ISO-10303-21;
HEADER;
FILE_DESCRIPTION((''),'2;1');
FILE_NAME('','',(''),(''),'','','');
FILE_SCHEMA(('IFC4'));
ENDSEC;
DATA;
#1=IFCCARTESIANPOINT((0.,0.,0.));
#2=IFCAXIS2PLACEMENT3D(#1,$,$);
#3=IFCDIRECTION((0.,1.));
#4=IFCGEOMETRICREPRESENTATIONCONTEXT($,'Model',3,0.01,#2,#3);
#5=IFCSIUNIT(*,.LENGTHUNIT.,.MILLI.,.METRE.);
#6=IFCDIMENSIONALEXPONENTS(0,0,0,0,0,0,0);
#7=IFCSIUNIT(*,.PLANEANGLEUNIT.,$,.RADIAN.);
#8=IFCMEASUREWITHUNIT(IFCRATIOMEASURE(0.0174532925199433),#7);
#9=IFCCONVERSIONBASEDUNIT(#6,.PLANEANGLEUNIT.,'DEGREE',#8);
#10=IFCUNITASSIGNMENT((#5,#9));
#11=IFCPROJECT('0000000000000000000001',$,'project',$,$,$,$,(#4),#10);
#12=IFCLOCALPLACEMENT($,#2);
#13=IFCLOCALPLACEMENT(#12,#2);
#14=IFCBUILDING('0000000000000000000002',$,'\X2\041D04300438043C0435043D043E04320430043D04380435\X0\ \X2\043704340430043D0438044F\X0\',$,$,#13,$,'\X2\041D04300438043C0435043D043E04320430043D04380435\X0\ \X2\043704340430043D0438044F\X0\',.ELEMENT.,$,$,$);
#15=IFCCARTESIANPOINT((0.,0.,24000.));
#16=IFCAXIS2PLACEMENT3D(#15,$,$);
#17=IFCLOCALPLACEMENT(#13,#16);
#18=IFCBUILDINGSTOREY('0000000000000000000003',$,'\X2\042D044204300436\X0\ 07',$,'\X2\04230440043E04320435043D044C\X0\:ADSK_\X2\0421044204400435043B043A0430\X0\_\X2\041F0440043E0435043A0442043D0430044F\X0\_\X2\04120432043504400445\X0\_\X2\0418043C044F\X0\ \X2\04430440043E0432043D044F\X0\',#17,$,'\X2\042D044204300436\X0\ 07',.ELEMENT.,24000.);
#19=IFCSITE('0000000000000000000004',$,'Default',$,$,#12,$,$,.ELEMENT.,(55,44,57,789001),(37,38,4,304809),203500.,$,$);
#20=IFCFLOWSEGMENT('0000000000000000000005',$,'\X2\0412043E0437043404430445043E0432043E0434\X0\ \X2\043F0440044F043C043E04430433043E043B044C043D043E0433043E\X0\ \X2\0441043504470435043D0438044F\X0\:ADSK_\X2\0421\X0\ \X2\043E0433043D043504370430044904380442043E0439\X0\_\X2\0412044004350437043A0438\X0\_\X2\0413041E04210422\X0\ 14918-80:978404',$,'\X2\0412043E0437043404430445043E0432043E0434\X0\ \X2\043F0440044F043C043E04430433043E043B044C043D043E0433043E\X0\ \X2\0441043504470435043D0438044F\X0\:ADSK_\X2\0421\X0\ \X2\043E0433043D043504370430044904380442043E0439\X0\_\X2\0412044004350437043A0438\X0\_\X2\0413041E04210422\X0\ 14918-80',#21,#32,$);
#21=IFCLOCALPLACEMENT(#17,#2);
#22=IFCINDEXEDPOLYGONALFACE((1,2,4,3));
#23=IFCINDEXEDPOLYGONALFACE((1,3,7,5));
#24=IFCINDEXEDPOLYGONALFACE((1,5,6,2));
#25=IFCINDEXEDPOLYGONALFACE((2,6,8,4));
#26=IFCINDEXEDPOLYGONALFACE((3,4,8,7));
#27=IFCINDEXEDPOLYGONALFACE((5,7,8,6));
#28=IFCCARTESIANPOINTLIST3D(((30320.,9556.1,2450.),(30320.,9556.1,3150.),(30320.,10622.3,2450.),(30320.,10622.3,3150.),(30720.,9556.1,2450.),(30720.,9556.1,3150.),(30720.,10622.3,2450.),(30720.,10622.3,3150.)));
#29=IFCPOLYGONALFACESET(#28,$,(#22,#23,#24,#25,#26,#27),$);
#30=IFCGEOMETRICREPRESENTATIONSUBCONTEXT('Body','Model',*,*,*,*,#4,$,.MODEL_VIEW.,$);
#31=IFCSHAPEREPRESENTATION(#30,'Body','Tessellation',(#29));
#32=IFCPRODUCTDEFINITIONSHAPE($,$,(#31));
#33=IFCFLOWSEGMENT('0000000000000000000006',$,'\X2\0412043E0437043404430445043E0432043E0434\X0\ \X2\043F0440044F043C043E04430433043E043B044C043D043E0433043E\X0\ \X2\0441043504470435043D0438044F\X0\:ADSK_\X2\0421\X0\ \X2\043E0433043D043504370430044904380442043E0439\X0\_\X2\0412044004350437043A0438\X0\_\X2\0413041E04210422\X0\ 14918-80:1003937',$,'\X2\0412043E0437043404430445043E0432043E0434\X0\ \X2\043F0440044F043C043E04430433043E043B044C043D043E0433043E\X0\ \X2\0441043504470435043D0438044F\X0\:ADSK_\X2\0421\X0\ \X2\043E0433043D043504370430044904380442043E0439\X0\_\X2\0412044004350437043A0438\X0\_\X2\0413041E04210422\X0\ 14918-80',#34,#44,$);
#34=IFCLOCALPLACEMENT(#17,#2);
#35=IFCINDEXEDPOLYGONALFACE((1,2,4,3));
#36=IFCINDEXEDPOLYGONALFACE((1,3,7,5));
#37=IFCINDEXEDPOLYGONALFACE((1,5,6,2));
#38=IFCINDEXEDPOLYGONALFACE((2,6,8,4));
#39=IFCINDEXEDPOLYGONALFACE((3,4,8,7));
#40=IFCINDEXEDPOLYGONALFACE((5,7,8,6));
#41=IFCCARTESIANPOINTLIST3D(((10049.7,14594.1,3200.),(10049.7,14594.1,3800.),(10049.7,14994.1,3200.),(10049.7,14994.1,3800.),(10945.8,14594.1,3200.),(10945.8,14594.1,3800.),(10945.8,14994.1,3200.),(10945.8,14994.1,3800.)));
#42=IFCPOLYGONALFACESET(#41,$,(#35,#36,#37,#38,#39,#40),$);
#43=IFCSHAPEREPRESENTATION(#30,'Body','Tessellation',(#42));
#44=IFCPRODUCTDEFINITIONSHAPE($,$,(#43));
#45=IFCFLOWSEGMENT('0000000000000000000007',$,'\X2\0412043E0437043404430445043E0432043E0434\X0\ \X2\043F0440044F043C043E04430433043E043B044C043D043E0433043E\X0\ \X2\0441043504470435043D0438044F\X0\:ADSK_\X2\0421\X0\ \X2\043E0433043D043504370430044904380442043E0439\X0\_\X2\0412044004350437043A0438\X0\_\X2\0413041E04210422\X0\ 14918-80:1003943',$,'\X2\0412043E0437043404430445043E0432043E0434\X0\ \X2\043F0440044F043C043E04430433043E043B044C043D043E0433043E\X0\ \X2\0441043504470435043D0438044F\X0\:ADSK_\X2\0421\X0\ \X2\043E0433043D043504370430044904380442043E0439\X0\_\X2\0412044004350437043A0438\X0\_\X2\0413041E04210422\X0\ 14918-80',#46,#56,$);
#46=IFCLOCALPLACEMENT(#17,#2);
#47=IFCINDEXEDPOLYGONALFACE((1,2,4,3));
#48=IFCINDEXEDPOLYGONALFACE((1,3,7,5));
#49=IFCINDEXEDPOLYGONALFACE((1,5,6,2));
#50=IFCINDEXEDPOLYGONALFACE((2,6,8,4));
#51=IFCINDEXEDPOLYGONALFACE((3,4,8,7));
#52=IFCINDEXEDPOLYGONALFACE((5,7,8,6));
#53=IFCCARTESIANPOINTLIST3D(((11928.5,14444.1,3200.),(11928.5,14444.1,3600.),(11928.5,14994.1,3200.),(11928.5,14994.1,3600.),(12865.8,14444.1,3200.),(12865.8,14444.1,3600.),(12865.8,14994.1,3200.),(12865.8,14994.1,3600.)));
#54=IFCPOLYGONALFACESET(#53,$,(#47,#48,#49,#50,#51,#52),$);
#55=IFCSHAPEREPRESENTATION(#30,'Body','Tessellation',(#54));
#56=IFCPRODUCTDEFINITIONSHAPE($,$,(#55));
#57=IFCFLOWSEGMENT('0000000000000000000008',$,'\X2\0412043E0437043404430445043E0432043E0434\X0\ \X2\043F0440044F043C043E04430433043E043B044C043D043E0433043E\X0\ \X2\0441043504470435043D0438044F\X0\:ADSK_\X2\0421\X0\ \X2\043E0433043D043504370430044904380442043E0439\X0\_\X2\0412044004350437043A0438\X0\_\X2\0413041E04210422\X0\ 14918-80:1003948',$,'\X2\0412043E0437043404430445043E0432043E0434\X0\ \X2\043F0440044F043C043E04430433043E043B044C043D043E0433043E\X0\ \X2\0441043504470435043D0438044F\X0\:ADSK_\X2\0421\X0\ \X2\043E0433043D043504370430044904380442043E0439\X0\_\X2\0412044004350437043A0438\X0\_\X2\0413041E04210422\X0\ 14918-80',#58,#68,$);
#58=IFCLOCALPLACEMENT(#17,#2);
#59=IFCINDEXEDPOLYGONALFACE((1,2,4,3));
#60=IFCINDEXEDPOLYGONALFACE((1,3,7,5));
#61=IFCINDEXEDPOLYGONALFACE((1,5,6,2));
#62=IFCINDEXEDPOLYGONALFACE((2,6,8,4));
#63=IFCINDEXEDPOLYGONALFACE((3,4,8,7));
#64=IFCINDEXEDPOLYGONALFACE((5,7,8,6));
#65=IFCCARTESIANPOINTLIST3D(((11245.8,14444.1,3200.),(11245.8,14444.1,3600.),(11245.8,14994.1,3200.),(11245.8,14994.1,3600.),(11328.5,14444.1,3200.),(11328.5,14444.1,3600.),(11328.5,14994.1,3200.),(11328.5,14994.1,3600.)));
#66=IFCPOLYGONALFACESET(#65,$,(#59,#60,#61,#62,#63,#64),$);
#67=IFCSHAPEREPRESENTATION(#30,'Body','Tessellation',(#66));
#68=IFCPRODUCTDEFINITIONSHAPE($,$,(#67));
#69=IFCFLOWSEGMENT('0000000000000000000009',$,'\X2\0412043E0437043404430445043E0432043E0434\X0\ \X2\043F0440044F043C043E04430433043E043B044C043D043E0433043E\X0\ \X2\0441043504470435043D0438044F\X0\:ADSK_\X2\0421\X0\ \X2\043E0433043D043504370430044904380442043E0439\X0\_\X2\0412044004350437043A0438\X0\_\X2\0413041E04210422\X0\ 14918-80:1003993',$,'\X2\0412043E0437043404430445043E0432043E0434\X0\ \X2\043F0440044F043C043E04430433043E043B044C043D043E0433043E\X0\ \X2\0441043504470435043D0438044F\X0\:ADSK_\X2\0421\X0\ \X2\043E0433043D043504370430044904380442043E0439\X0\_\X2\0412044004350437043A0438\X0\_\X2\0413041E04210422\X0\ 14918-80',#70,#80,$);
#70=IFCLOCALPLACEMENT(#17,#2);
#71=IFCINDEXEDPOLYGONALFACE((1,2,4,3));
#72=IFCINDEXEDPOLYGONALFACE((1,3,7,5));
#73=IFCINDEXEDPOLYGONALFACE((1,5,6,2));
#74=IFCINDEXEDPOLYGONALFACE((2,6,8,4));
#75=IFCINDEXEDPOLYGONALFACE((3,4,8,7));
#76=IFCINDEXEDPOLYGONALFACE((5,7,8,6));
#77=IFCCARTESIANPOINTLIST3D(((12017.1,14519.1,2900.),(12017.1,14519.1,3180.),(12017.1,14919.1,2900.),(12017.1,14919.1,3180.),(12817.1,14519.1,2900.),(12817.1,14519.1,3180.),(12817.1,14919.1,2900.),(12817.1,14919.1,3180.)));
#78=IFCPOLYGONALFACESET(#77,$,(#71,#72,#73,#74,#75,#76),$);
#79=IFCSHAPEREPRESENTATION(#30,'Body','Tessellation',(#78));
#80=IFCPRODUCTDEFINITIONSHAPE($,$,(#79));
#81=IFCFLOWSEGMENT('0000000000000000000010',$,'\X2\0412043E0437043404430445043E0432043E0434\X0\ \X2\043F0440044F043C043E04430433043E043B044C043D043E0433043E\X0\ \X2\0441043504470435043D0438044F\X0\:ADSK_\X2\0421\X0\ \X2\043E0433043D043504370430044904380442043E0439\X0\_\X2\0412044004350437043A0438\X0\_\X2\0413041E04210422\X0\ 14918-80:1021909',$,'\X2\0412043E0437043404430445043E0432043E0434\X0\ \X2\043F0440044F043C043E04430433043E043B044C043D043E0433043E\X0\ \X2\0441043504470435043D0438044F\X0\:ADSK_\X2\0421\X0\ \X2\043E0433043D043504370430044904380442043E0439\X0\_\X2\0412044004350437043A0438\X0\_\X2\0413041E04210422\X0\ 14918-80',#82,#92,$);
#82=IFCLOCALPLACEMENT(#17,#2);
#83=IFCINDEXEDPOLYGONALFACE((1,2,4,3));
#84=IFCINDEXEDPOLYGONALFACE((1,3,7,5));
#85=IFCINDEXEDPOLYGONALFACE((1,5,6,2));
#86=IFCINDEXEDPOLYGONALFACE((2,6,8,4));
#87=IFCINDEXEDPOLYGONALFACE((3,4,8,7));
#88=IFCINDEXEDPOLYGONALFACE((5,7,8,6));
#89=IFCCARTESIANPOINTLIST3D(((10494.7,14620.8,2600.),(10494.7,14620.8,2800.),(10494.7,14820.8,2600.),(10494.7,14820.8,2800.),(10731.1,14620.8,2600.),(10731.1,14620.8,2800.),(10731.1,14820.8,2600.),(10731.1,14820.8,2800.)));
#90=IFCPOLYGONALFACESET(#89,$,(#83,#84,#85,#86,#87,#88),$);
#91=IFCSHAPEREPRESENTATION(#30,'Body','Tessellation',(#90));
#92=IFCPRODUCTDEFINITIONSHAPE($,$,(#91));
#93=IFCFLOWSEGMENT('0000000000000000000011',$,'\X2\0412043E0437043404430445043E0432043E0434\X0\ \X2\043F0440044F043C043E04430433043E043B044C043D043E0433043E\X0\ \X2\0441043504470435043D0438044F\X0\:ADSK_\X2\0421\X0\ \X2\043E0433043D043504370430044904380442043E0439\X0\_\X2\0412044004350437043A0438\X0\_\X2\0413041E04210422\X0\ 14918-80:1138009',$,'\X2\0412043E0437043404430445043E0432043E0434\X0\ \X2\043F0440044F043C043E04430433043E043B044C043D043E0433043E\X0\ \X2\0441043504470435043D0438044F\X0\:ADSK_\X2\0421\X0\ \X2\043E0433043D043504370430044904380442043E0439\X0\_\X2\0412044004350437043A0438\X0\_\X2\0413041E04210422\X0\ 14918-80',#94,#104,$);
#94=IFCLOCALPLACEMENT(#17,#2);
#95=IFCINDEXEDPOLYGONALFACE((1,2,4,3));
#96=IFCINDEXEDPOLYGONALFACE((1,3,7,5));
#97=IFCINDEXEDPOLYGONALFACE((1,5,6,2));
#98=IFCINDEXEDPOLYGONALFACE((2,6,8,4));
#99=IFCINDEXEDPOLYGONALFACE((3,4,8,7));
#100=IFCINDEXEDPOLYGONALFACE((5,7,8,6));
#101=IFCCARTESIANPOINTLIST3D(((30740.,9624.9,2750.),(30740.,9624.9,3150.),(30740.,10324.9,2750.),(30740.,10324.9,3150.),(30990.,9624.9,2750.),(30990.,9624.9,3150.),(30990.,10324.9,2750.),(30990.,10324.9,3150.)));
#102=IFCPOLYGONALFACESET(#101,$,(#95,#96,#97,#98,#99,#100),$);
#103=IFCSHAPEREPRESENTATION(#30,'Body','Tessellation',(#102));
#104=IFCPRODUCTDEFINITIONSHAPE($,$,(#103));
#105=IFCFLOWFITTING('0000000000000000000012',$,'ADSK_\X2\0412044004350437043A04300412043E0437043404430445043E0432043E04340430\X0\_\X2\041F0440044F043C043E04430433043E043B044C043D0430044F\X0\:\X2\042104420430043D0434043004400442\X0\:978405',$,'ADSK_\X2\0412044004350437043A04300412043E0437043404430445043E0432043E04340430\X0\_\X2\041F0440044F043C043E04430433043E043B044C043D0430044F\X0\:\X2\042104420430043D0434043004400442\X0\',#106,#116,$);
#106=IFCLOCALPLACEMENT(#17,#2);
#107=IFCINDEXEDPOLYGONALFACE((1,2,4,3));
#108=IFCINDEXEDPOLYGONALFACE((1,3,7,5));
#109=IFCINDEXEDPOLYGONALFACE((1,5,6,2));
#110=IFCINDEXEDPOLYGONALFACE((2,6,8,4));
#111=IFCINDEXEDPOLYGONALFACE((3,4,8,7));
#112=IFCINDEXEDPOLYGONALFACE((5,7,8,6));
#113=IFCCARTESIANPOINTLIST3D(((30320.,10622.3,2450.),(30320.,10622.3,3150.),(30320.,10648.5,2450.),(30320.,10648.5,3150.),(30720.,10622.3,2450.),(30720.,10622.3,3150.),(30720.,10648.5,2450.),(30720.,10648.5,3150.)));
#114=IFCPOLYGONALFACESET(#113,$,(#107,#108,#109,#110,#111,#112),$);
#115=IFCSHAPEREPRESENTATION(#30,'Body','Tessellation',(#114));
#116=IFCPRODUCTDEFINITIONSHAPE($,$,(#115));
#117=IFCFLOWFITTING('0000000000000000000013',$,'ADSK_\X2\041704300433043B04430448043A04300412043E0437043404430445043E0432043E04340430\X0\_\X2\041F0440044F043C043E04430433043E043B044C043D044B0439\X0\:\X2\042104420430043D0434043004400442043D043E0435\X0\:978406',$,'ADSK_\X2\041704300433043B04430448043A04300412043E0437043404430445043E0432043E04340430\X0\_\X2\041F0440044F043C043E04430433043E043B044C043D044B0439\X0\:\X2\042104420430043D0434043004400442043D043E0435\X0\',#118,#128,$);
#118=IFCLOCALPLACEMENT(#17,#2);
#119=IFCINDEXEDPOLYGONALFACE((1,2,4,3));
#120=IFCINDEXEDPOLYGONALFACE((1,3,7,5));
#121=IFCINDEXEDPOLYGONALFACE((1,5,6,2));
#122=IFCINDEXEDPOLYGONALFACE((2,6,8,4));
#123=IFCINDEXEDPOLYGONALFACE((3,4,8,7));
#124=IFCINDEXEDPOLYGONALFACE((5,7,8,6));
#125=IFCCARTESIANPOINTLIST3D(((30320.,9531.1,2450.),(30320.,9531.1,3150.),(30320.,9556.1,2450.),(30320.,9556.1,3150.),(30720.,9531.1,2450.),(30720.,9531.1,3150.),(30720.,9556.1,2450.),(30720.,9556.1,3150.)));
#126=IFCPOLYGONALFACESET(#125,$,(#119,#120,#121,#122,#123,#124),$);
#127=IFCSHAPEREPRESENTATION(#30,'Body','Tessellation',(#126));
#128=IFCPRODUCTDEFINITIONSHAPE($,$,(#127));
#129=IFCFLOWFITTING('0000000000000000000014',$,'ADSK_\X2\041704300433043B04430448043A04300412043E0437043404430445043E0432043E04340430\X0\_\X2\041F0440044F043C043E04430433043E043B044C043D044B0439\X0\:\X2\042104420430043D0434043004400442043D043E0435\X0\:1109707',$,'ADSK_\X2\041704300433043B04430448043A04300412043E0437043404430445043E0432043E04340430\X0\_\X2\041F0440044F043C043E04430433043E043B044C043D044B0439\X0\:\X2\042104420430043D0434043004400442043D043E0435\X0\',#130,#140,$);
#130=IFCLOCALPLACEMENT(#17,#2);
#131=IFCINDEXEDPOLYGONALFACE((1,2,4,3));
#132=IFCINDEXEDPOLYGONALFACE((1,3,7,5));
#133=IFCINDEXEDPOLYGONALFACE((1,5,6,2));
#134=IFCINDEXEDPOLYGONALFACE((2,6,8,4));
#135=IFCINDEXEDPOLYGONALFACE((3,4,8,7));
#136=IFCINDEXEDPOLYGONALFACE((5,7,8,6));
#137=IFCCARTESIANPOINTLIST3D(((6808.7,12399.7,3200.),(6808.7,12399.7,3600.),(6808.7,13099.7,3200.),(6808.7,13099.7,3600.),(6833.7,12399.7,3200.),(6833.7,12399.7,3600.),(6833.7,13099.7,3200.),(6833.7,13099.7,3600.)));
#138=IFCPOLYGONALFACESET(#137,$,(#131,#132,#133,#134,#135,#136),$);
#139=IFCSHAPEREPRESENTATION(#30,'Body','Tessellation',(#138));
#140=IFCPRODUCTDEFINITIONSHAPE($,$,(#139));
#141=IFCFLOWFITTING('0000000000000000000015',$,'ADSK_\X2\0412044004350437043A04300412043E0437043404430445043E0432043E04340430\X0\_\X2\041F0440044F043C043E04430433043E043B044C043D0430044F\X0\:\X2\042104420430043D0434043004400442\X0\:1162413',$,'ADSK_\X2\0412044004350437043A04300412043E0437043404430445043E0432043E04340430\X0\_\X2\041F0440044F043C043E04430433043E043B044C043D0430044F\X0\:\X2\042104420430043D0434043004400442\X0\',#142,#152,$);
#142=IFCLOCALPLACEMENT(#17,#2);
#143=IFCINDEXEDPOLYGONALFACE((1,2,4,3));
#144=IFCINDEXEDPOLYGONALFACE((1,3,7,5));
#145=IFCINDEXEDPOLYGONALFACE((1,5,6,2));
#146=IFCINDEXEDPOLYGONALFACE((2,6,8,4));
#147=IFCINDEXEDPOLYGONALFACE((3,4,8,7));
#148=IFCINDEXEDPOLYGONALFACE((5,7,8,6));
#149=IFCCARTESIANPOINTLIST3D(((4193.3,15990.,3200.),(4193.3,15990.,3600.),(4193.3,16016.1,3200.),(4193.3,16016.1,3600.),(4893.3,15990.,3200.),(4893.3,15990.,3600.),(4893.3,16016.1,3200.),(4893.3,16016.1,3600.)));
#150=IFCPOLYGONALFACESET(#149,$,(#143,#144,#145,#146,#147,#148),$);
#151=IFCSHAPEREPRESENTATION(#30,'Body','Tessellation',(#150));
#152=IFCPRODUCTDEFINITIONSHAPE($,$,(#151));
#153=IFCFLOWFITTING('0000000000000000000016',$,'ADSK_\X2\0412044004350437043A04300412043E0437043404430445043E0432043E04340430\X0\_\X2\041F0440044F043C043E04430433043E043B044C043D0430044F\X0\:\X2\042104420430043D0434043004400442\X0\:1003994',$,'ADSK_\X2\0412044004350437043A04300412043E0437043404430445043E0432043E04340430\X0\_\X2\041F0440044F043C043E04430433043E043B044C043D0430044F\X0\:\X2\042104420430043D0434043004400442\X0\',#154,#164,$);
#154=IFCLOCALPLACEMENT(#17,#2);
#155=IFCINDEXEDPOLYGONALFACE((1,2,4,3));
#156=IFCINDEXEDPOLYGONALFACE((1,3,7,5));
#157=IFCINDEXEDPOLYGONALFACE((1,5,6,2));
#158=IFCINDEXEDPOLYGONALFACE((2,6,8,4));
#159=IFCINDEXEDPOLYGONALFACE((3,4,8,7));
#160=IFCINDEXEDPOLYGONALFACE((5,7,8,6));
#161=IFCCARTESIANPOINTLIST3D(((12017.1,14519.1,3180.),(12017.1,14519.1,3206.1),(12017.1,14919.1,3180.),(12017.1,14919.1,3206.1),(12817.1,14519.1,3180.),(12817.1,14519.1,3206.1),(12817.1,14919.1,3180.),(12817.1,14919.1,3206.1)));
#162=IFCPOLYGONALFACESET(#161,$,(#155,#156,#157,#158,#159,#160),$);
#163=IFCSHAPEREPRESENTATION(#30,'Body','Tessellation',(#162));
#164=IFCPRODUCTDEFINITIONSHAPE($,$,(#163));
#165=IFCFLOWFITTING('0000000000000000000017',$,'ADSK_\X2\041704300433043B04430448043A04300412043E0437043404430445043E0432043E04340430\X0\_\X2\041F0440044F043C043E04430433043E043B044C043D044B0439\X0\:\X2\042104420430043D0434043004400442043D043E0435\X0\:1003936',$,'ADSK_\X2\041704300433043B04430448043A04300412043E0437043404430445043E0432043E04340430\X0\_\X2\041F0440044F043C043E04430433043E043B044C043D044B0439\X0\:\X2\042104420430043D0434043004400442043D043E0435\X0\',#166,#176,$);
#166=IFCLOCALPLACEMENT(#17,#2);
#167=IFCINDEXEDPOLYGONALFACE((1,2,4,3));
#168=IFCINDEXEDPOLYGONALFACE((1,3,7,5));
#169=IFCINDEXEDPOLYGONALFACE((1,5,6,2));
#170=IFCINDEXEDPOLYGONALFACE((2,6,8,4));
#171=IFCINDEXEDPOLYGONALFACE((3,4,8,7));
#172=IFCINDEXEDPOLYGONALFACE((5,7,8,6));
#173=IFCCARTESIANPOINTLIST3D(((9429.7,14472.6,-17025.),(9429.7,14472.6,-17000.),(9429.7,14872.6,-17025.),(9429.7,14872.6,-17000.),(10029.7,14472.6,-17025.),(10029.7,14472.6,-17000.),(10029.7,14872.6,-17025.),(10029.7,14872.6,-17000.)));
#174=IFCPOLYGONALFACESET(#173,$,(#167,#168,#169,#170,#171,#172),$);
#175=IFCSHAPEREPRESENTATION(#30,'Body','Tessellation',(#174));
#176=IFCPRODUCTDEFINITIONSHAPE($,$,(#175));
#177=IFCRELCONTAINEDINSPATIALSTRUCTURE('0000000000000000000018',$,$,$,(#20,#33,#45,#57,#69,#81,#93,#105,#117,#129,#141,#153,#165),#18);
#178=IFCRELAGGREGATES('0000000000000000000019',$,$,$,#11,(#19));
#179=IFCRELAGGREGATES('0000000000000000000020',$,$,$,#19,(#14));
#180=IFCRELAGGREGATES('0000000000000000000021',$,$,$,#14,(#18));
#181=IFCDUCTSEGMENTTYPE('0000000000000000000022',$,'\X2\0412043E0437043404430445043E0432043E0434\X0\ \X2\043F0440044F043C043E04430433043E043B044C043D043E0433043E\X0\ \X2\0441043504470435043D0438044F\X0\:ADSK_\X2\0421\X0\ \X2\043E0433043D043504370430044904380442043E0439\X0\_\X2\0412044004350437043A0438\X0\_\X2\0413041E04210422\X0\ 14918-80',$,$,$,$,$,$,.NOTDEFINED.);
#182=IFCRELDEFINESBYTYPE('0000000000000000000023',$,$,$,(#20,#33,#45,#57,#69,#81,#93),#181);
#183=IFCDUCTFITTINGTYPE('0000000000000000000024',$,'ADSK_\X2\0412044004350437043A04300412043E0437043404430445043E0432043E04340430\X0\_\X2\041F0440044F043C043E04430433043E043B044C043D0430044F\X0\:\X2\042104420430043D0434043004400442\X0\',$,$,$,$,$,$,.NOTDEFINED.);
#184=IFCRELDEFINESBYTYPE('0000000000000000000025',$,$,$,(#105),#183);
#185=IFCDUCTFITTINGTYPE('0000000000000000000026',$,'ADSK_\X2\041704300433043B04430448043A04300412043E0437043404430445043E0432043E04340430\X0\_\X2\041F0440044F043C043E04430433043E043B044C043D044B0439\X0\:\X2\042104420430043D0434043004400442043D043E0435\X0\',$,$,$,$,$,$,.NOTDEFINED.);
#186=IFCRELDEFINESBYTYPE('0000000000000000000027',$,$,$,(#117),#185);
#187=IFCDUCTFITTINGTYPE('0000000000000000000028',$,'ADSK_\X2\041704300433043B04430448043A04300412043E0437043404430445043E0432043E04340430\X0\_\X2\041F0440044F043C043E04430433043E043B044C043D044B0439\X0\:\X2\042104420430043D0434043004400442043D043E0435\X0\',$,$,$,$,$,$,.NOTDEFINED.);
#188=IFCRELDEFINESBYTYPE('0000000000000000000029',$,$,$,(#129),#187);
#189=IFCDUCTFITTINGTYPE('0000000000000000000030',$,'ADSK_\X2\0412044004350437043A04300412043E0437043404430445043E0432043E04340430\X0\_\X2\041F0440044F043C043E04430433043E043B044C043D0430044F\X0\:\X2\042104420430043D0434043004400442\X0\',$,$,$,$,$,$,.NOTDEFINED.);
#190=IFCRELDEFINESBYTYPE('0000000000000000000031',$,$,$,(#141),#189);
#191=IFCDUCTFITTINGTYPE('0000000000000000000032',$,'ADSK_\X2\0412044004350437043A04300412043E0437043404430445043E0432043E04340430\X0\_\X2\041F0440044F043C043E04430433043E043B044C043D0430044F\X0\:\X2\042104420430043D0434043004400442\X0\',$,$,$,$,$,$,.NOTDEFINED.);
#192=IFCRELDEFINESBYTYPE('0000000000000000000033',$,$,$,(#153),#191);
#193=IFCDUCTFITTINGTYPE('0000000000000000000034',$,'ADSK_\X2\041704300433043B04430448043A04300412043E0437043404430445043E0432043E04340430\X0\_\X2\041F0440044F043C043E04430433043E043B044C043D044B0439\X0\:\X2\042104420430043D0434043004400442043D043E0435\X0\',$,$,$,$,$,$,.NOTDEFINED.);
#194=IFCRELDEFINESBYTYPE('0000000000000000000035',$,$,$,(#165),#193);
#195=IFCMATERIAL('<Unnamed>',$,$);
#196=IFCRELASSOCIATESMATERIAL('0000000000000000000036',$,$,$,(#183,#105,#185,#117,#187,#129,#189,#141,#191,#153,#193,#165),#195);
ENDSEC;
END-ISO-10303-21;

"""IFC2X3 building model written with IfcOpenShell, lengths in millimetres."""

from ifc_helpers import new_model, entity, si_unit, converted_unit, direction, frame, frame_2d, origin, origin_2d_with_axis, place, context, subcontext, project, spatial, rectangle, extrude, source, transform, mapped, material, type_object, type_shapes, element, save


model = new_model("IFC2X3")

# Units and contexts
model_context = context("Model", 3, precision=0.01, world=origin(), true_north=direction((0.0, 1.0)))
body_context = subcontext(model_context, "Body", "Model", "MODEL_VIEW")
ifc_project = project(units=[si_unit("LENGTHUNIT", "METRE", prefix="MILLI"), converted_unit("PLANEANGLEUNIT", "DEGREE", entity("IfcRatioMeasure", 0.0174532925199433), si_unit("PLANEANGLEUNIT", "RADIAN"), dimensions=[0, 0, 0, 0, 0, 0, 0])], contexts=[model_context])

# Site, building, storey
site_placement = place(None, frame((0.0, 0.0, 0.0)))
site = spatial("IfcSite", under=ifc_project, at=site_placement, Name="Default", CompositionType="ELEMENT", RefLatitude=(55, 44, 57, 789001), RefLongitude=(37, 38, 4, 304809), RefElevation=203500.0)
building_placement = place(site_placement, origin())
building = spatial("IfcBuilding", under=site, at=building_placement, Name="Наименование здания", LongName="Наименование здания", CompositionType="ELEMENT")
storey_placement = place(building_placement, frame((0.0, 0.0, 24000.0)))
storey = spatial("IfcBuildingStorey", under=building, at=storey_placement, Name="Этаж 07", ObjectType="Уровень:ADSK_Стрелка_Проектная_Вверх_Имя уровня", LongName="Этаж 07", CompositionType="ELEMENT", Elevation=24000.0)

# Flow segments
duct_segment_type_1 = type_object("IfcDuctSegmentType", Name="Воздуховод прямоугольного сечения:ADSK_С огнезащитой_Врезки_ГОСТ 14918-80", PredefinedType="NOTDEFINED")
flow_segment_1_placement = place(storey_placement, frame((30320.0, 9556.1, 2450.0)))
element("IfcFlowSegment", 1, at=flow_segment_1_placement, inside=storey, type_object=duct_segment_type_1, Name="Воздуховод прямоугольного сечения:ADSK_С огнезащитой_Врезки_ГОСТ 14918-80:978404", ObjectType="Воздуховод прямоугольного сечения:ADSK_С огнезащитой_Врезки_ГОСТ 14918-80", context=body_context, shape_type="SweptSolid", body=[
    extrude(rectangle(XDim=1066.2, YDim=400.0, at=frame_2d((0.0, 0.0), x_axis=(1.0, 0.0))), frame((200.0, 533.1, 0.0), z_axis=(0.0, 0.0, 1.0), x_axis=(0.0, -1.0, 0.0)), (0.0, 0.0, 1.0), 700.0),
])
flow_segment_2_placement = place(storey_placement, frame((10049.7, 14594.1, 3200.0)))
element("IfcFlowSegment", 2, at=flow_segment_2_placement, inside=storey, type_object=duct_segment_type_1, Name="Воздуховод прямоугольного сечения:ADSK_С огнезащитой_Врезки_ГОСТ 14918-80:1003937", ObjectType="Воздуховод прямоугольного сечения:ADSK_С огнезащитой_Врезки_ГОСТ 14918-80", context=body_context, shape_type="SweptSolid", body=[
    extrude(rectangle(XDim=896.0, YDim=400.0, at=origin_2d_with_axis()), frame((448.0, 200.0, 0.0), z_axis=(0.0, 0.0, 1.0), x_axis=(-1.0, 0.0, 0.0)), (0.0, 0.0, 1.0), 600.0),
])
flow_segment_3_placement = place(storey_placement, frame((11928.5, 14444.1, 3200.0)))
element("IfcFlowSegment", 3, at=flow_segment_3_placement, inside=storey, type_object=duct_segment_type_1, Name="Воздуховод прямоугольного сечения:ADSK_С огнезащитой_Врезки_ГОСТ 14918-80:1003943", ObjectType="Воздуховод прямоугольного сечения:ADSK_С огнезащитой_Врезки_ГОСТ 14918-80", context=body_context, shape_type="SweptSolid", body=[
    extrude(rectangle(XDim=937.3, YDim=550.0, at=frame_2d((0.0, 0.0), x_axis=(1.0, 0.0))), frame((468.6, 275.0, 0.0)), (0.0, 0.0, 1.0), 400.0),
])
flow_segment_4_placement = place(storey_placement, frame((11245.8, 14444.1, 3200.0)))
element("IfcFlowSegment", 4, at=flow_segment_4_placement, inside=storey, type_object=duct_segment_type_1, Name="Воздуховод прямоугольного сечения:ADSK_С огнезащитой_Врезки_ГОСТ 14918-80:1003948", ObjectType="Воздуховод прямоугольного сечения:ADSK_С огнезащитой_Врезки_ГОСТ 14918-80", context=body_context, shape_type="SweptSolid", body=[
    extrude(rectangle(XDim=82.7, YDim=550.0, at=frame_2d((0.0, 0.0), x_axis=(1.0, 0.0))), frame((41.4, 275.0, 0.0)), (0.0, 0.0, 1.0), 400.0),
])
flow_segment_5_placement = place(storey_placement, frame((12017.1, 14519.1, 2900.0)))
element("IfcFlowSegment", 5, at=flow_segment_5_placement, inside=storey, type_object=duct_segment_type_1, Name="Воздуховод прямоугольного сечения:ADSK_С огнезащитой_Врезки_ГОСТ 14918-80:1003993", ObjectType="Воздуховод прямоугольного сечения:ADSK_С огнезащитой_Врезки_ГОСТ 14918-80", context=body_context, shape_type="SweptSolid", body=[
    extrude(rectangle(XDim=800.0, YDim=400.0, at=frame_2d((0.0, 0.0), x_axis=(1.0, 0.0))), frame((400.0, 200.0, 0.0)), (0.0, 0.0, 1.0), 280.0),
])
flow_segment_6_placement = place(storey_placement, frame((10494.7, 14620.8, 2600.0)))
element("IfcFlowSegment", 6, at=flow_segment_6_placement, inside=storey, type_object=duct_segment_type_1, Name="Воздуховод прямоугольного сечения:ADSK_С огнезащитой_Врезки_ГОСТ 14918-80:1021909", ObjectType="Воздуховод прямоугольного сечения:ADSK_С огнезащитой_Врезки_ГОСТ 14918-80", context=body_context, shape_type="SweptSolid", body=[
    extrude(rectangle(XDim=236.4, YDim=200.0, at=frame_2d((0.0, 0.0), x_axis=(1.0, 0.0))), frame((118.2, 100.0, 0.0), z_axis=(0.0, 0.0, 1.0), x_axis=(-1.0, 0.0, 0.0)), (0.0, 0.0, 1.0), 200.0),
])
flow_segment_7_placement = place(storey_placement, frame((30740.0, 9624.9, 2750.0)))
element("IfcFlowSegment", 7, at=flow_segment_7_placement, inside=storey, type_object=duct_segment_type_1, Name="Воздуховод прямоугольного сечения:ADSK_С огнезащитой_Врезки_ГОСТ 14918-80:1138009", ObjectType="Воздуховод прямоугольного сечения:ADSK_С огнезащитой_Врезки_ГОСТ 14918-80", context=body_context, shape_type="SweptSolid", body=[
    extrude(rectangle(XDim=250.0, YDim=700.0, at=frame_2d((0.0, 0.0), x_axis=(1.0, 0.0))), frame((125.0, 350.0, 0.0), z_axis=(0.0, 0.0, 1.0), x_axis=(-1.0, 0.0, 0.0)), (0.0, 0.0, 1.0), 400.0),
])

# Flow fittings
ifc_material_1 = material(Name="<Unnamed>")
duct_fitting_type_1 = type_object("IfcDuctFittingType", Name="ADSK_ВрезкаВоздуховода_Прямоугольная:Стандарт", PredefinedType="NOTDEFINED", material=ifc_material_1)
shared_shape_1 = source(origin(), body_context, "Body", "SweptSolid", [
    extrude(rectangle(XDim=26.1, YDim=700.0, at=frame_2d((0.0, 0.0), x_axis=(1.0, 0.0))), frame((6.9, 0.0, -200.0)), (0.0, 0.0, 1.0), 400.0),
])
type_shapes(duct_fitting_type_1, [shared_shape_1])
flow_fitting_1_placement = place(storey_placement, frame((30520.0, 10642.3, 2800.0), z_axis=(-1.0, 0.0, 0.0), x_axis=(0.0, -1.0, 0.0)))
element("IfcFlowFitting", 8, at=flow_fitting_1_placement, inside=storey, type_object=duct_fitting_type_1, material=ifc_material_1, Name="ADSK_ВрезкаВоздуховода_Прямоугольная:Стандарт:978405", ObjectType="ADSK_ВрезкаВоздуховода_Прямоугольная:Стандарт", context=body_context, shape_type="MappedRepresentation", body=[
    mapped(shared_shape_1, transform((0.0, 0.0, 0.0), scale=1.0)),
])
duct_fitting_type_2 = type_object("IfcDuctFittingType", Name="ADSK_ЗаглушкаВоздуховода_Прямоугольный:Стандартное", PredefinedType="NOTDEFINED", material=ifc_material_1)
shared_shape_2 = source(origin(), body_context, "Body", "SweptSolid", [
    extrude(rectangle(XDim=25.0, YDim=400.0, at=frame_2d((0.0, 0.0), x_axis=(1.0, 0.0))), frame((12.5, 0.0, -350.0)), (0.0, 0.0, 1.0), 700.0),
])
type_shapes(duct_fitting_type_2, [shared_shape_2])
flow_fitting_2_placement = place(storey_placement, frame((30520.0, 9556.1, 2800.0), z_axis=(0.0, 0.0, 1.0), x_axis=(0.0, -1.0, 0.0)))
element("IfcFlowFitting", 9, at=flow_fitting_2_placement, inside=storey, type_object=duct_fitting_type_2, material=ifc_material_1, Name="ADSK_ЗаглушкаВоздуховода_Прямоугольный:Стандартное:978406", ObjectType="ADSK_ЗаглушкаВоздуховода_Прямоугольный:Стандартное", context=body_context, shape_type="MappedRepresentation", body=[
    mapped(shared_shape_2, transform((0.0, 0.0, 0.0), scale=1.0)),
])
duct_fitting_type_3 = type_object("IfcDuctFittingType", Name="ADSK_ЗаглушкаВоздуховода_Прямоугольный:Стандартное", PredefinedType="NOTDEFINED", material=ifc_material_1)
shared_shape_3 = source(origin(), body_context, "Body", "SweptSolid", [
    extrude(rectangle(XDim=25.0, YDim=700.0, at=frame_2d((0.0, 0.0), x_axis=(1.0, 0.0))), frame((12.5, 0.0, -200.0)), (0.0, 0.0, 1.0), 400.0),
])
type_shapes(duct_fitting_type_3, [shared_shape_3])
flow_fitting_3_placement = place(storey_placement, frame((6808.7, 12749.7, 3400.0)))
element("IfcFlowFitting", 10, at=flow_fitting_3_placement, inside=storey, type_object=duct_fitting_type_3, material=ifc_material_1, Name="ADSK_ЗаглушкаВоздуховода_Прямоугольный:Стандартное:1109707", ObjectType="ADSK_ЗаглушкаВоздуховода_Прямоугольный:Стандартное", context=body_context, shape_type="MappedRepresentation", body=[
    mapped(shared_shape_3, transform((0.0, 0.0, 0.0), scale=1.0)),
])
duct_fitting_type_4 = type_object("IfcDuctFittingType", Name="ADSK_ВрезкаВоздуховода_Прямоугольная:Стандарт", PredefinedType="NOTDEFINED", material=ifc_material_1)
shared_shape_4 = source(origin(), body_context, "Body", "SweptSolid", [
    extrude(rectangle(XDim=26.1, YDim=400.0, at=frame_2d((0.0, 0.0), x_axis=(1.0, 0.0))), frame((7.0, 0.0, -350.0)), (0.0, 0.0, 1.0), 700.0),
])
type_shapes(duct_fitting_type_4, [shared_shape_4])
flow_fitting_4_placement = place(storey_placement, frame((4543.3, 16010.0, 3400.0), z_axis=(-1.0, 0.0, 0.0), x_axis=(0.0, -1.0, 0.0)))
element("IfcFlowFitting", 11, at=flow_fitting_4_placement, inside=storey, type_object=duct_fitting_type_4, material=ifc_material_1, Name="ADSK_ВрезкаВоздуховода_Прямоугольная:Стандарт:1162413", ObjectType="ADSK_ВрезкаВоздуховода_Прямоугольная:Стандарт", context=body_context, shape_type="MappedRepresentation", body=[
    mapped(shared_shape_4, transform((0.0, 0.0, 0.0), scale=1.0)),
])
duct_fitting_type_5 = type_object("IfcDuctFittingType", Name="ADSK_ВрезкаВоздуховода_Прямоугольная:Стандарт", PredefinedType="NOTDEFINED", material=ifc_material_1)
shared_shape_5 = source(origin(), body_context, "Body", "SweptSolid", [
    extrude(rectangle(XDim=800.0, YDim=26.1, at=frame_2d((0.0, 0.0), x_axis=(1.0, 0.0))), frame((7.0, 0.0, -200.0), z_axis=(0.0, 0.0, 1.0), x_axis=(0.0, -1.0, 0.0)), (0.0, 0.0, 1.0), 400.0),
])
type_shapes(duct_fitting_type_5, [shared_shape_5])
flow_fitting_5_placement = place(storey_placement, frame((12417.1, 14719.1, 3200.0), z_axis=(0.0, 1.0, 0.0), x_axis=(0.0, 0.0, -1.0)))
element("IfcFlowFitting", 12, at=flow_fitting_5_placement, inside=storey, type_object=duct_fitting_type_5, material=ifc_material_1, Name="ADSK_ВрезкаВоздуховода_Прямоугольная:Стандарт:1003994", ObjectType="ADSK_ВрезкаВоздуховода_Прямоугольная:Стандарт", context=body_context, shape_type="MappedRepresentation", body=[
    mapped(shared_shape_5, transform((0.0, 0.0, 0.0), scale=1.0)),
])
duct_fitting_type_6 = type_object("IfcDuctFittingType", Name="ADSK_ЗаглушкаВоздуховода_Прямоугольный:Стандартное", PredefinedType="NOTDEFINED", material=ifc_material_1)
shared_shape_6 = source(origin(), body_context, "Body", "SweptSolid", [
    extrude(rectangle(XDim=25.0, YDim=600.0, at=frame_2d((0.0, 0.0), x_axis=(1.0, 0.0))), frame((12.5, 0.0, -200.0)), (0.0, 0.0, 1.0), 400.0),
])
type_shapes(duct_fitting_type_6, [shared_shape_6])
flow_fitting_6_placement = place(storey_placement, frame((9729.7, 14672.6, -17000.0), z_axis=(0.0, -1.0, 0.0), x_axis=(0.0, 0.0, -1.0)))
element("IfcFlowFitting", 13, at=flow_fitting_6_placement, inside=storey, type_object=duct_fitting_type_6, material=ifc_material_1, Name="ADSK_ЗаглушкаВоздуховода_Прямоугольный:Стандартное:1003936", ObjectType="ADSK_ЗаглушкаВоздуховода_Прямоугольный:Стандартное", context=body_context, shape_type="MappedRepresentation", body=[
    mapped(shared_shape_6, transform((0.0, 0.0, 0.0), scale=1.0)),
])

save(model, "model.ifc")
